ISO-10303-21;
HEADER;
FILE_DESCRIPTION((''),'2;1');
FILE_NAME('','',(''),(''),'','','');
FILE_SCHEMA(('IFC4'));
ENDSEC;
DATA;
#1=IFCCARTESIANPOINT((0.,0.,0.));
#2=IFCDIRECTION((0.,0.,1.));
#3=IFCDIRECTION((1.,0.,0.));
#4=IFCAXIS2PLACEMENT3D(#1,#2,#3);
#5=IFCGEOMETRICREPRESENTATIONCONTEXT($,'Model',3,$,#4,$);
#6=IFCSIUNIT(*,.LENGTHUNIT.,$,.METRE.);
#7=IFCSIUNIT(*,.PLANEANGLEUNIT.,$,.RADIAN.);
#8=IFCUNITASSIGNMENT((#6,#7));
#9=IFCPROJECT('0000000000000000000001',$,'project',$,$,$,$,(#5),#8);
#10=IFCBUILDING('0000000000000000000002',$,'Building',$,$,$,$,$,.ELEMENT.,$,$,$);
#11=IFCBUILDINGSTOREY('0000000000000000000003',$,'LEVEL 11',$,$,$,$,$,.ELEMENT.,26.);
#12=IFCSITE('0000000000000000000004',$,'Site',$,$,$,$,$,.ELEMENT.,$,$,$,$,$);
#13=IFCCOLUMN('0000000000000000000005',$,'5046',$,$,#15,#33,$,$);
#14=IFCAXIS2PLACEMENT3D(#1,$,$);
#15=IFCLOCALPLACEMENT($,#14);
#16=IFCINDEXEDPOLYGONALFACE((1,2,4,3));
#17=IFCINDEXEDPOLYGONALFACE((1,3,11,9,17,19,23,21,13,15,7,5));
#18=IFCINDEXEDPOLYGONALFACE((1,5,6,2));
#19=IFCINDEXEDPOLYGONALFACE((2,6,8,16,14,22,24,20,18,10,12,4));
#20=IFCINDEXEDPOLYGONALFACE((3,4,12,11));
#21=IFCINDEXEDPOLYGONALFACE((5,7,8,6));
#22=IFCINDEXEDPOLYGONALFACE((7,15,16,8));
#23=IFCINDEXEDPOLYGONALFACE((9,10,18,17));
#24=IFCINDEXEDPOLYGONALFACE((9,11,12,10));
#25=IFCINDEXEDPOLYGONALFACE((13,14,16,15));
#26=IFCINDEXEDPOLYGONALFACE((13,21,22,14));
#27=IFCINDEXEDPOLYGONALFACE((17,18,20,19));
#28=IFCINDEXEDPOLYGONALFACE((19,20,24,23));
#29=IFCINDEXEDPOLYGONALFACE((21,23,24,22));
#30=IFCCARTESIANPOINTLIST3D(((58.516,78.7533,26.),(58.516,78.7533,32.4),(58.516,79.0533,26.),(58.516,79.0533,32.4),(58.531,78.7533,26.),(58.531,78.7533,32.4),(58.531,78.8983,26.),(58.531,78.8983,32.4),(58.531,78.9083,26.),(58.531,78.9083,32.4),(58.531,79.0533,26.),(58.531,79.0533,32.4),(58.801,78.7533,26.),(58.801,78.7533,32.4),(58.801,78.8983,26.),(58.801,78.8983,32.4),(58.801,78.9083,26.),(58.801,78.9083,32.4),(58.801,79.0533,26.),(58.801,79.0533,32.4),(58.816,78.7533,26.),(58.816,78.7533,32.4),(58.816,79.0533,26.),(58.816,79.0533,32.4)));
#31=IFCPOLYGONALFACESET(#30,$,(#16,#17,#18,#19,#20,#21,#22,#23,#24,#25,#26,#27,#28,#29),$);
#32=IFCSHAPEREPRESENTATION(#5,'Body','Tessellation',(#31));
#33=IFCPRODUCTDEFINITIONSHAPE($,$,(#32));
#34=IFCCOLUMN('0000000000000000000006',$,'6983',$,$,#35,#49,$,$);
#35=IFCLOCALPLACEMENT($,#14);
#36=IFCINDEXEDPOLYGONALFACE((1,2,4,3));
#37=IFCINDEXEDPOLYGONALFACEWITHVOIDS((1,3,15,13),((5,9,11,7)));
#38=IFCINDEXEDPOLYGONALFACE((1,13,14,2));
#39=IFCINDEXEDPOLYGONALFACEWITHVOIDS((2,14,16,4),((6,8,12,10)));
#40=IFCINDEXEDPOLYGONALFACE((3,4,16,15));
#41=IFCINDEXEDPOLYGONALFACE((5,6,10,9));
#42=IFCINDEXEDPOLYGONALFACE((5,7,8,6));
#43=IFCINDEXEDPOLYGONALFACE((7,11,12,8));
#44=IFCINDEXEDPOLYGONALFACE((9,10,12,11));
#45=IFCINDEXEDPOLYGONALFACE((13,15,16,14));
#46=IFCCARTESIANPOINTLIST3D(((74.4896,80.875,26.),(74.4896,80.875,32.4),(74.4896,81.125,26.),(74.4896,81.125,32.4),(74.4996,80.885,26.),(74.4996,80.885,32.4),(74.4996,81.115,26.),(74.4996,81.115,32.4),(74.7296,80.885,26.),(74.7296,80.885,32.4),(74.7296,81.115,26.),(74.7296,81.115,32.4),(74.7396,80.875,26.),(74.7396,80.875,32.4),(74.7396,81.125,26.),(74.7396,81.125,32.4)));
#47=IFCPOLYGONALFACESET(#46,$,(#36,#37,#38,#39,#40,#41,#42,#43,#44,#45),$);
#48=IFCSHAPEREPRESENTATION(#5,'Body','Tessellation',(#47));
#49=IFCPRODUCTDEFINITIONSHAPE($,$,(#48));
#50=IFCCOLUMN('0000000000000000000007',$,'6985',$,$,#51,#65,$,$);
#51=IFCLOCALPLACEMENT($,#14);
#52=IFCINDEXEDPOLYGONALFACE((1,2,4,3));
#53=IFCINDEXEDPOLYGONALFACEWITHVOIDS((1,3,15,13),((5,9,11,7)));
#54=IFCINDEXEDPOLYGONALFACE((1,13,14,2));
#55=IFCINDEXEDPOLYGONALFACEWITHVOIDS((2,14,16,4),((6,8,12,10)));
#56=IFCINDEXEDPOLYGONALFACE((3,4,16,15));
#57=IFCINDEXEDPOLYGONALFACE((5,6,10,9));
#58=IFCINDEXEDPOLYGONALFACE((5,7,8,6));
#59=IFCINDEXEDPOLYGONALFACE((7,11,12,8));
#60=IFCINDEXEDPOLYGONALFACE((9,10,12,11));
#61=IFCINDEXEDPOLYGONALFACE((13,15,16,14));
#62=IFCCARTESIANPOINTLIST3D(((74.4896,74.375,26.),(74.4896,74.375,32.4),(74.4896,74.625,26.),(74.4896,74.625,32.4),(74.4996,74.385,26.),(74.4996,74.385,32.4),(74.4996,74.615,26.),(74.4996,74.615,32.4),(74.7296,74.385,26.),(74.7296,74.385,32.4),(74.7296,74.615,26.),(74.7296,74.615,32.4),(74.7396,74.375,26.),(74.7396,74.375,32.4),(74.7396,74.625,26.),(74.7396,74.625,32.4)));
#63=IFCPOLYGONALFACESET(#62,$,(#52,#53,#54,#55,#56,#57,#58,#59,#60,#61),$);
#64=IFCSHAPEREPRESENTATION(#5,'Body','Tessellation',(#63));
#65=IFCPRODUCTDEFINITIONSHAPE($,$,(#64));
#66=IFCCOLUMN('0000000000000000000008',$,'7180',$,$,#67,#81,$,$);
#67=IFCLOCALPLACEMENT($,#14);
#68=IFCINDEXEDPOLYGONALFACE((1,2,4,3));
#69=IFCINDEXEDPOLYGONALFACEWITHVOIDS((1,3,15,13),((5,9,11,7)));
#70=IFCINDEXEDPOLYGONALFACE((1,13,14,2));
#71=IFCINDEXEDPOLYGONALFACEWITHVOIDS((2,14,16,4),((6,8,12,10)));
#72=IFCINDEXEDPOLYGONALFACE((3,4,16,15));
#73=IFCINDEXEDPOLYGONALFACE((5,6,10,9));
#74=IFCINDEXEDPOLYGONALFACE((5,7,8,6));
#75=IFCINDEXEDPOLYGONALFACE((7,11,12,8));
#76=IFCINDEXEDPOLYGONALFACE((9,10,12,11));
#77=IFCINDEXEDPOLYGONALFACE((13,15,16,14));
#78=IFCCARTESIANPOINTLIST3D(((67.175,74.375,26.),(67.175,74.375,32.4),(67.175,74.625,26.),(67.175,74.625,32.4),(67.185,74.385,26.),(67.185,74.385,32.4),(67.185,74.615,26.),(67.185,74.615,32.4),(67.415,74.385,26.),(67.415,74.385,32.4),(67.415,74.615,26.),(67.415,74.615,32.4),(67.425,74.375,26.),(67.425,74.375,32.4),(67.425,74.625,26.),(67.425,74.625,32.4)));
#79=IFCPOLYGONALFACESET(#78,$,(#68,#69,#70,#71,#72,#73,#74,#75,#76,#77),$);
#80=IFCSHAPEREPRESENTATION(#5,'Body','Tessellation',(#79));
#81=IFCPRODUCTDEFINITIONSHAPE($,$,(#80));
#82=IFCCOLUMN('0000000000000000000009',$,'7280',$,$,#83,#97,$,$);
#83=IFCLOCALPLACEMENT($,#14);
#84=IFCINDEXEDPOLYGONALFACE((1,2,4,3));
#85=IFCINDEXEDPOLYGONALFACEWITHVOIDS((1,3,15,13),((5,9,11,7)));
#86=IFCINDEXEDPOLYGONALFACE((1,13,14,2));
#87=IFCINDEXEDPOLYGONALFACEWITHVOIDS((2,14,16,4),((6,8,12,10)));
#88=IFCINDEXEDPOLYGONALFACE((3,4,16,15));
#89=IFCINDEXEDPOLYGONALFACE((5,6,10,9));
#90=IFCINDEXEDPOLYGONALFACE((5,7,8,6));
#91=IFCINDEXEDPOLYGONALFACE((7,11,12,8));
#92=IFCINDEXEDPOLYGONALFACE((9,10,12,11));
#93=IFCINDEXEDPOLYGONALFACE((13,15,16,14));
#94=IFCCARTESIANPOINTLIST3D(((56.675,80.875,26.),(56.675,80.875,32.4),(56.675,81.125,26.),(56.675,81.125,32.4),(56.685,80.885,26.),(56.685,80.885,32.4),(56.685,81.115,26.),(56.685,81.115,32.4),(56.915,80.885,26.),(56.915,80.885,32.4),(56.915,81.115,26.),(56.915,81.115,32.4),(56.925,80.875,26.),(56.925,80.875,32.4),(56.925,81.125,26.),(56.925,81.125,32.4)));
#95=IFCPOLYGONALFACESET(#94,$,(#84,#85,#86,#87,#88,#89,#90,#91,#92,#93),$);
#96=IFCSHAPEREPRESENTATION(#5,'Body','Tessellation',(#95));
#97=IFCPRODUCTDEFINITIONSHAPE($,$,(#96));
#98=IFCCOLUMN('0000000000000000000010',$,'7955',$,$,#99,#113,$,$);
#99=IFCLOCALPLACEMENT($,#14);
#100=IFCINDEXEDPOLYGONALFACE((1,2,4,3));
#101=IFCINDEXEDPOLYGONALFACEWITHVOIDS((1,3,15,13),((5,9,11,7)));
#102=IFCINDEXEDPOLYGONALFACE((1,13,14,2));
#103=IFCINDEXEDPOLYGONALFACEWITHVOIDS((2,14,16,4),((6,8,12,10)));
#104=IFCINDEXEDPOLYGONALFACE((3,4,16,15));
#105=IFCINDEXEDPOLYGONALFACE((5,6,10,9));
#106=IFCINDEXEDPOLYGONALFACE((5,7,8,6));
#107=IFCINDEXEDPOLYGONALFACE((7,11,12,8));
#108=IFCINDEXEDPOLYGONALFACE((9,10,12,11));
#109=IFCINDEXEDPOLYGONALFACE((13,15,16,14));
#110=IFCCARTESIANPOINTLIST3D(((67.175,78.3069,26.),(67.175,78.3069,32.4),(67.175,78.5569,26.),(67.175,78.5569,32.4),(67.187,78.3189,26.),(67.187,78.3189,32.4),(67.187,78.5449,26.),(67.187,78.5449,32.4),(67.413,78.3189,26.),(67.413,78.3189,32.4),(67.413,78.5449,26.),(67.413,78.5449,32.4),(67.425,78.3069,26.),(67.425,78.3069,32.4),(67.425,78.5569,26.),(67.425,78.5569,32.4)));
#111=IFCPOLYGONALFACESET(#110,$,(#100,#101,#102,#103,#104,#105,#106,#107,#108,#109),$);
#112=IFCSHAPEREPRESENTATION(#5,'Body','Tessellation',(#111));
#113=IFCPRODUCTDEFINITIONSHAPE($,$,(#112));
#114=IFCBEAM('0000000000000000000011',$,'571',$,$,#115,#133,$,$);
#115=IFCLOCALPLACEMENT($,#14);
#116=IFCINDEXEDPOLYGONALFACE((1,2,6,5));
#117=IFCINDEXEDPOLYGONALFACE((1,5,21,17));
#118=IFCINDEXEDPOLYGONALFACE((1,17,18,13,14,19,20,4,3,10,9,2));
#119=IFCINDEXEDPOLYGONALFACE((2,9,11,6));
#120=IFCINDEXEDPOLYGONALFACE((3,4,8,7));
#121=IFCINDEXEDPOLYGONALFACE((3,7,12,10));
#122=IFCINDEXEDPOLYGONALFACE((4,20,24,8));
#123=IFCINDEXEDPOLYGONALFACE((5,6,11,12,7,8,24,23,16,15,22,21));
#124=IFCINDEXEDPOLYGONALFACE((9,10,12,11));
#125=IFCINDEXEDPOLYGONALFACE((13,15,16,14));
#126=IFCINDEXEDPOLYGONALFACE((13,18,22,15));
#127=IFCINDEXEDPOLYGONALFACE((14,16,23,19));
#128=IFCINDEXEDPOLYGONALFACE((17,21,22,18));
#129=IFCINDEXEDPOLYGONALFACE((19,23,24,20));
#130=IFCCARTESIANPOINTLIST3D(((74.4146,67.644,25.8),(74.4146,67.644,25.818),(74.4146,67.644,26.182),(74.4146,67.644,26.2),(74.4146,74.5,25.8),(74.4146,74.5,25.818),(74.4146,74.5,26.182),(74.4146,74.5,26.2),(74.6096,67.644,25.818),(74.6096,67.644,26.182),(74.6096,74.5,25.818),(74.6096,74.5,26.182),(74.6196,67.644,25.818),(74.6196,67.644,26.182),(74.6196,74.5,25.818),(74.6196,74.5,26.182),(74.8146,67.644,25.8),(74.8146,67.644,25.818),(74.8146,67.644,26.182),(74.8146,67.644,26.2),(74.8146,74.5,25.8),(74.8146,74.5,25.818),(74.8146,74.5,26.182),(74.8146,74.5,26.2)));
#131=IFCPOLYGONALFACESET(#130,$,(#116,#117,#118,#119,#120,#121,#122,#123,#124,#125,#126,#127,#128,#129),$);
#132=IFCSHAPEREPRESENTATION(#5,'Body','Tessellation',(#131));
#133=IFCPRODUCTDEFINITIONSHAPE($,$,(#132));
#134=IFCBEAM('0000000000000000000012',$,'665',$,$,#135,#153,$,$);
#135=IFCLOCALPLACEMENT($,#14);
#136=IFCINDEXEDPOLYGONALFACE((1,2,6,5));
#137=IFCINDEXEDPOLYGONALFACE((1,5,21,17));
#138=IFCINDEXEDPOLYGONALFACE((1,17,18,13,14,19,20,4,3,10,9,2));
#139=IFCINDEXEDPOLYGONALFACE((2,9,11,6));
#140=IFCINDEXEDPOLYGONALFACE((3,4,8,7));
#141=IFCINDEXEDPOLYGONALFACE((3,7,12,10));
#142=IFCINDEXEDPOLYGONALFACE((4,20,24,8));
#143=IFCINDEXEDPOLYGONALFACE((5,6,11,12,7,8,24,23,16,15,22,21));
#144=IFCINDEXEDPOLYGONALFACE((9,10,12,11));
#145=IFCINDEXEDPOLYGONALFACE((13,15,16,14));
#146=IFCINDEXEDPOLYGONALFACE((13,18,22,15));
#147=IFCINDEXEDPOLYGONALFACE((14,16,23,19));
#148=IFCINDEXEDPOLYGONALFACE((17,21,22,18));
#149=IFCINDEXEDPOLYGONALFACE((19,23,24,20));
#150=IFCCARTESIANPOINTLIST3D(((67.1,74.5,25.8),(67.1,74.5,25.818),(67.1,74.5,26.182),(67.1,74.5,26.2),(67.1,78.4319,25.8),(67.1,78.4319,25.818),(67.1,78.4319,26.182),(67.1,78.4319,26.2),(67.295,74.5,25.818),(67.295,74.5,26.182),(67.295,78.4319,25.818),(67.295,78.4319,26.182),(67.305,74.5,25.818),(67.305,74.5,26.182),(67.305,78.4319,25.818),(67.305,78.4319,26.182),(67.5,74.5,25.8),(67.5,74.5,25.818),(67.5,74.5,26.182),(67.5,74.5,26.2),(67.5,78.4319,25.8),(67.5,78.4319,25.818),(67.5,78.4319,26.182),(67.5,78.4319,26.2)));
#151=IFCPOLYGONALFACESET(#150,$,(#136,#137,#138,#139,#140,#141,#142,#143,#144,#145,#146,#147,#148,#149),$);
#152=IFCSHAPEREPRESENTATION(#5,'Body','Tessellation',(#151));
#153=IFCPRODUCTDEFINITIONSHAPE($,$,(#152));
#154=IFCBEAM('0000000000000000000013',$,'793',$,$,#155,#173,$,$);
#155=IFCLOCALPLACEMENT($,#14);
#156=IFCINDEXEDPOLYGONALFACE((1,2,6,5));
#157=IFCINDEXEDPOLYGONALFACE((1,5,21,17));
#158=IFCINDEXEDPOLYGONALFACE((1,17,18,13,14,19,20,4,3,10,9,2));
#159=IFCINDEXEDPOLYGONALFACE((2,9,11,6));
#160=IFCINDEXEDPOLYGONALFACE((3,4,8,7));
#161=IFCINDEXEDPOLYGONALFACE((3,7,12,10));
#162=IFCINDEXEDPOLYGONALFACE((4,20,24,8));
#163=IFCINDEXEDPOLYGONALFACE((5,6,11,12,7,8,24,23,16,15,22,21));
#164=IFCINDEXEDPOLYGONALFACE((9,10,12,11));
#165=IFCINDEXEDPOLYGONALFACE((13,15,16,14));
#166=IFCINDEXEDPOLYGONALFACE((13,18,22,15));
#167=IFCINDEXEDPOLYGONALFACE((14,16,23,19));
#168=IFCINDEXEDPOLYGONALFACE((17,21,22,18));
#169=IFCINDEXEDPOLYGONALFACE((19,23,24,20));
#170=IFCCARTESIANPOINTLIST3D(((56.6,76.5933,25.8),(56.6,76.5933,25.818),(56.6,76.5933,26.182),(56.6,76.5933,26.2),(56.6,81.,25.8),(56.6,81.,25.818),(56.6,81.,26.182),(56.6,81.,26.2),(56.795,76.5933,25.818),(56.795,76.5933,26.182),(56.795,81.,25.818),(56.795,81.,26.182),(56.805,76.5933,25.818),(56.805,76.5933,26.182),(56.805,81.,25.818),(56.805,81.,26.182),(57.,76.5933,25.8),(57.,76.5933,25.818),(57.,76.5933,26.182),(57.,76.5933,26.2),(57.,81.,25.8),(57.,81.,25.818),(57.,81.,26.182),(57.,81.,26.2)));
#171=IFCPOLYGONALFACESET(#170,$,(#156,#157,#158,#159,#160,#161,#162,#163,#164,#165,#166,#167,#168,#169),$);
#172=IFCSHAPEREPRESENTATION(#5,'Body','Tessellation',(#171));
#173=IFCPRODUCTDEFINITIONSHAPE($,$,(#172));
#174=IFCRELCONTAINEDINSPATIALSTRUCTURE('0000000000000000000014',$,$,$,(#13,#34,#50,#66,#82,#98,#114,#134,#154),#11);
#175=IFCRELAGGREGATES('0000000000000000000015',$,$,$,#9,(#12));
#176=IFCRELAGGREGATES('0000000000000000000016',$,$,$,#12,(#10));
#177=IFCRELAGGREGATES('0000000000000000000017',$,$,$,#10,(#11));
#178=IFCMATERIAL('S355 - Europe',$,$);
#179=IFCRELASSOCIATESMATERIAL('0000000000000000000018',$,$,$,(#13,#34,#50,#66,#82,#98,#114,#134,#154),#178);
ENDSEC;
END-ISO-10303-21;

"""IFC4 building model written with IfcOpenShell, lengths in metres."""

from ifc_helpers import new_model, si_unit, frame, origin_with_axes, origin_2d_with_axis, place, context, project, spatial, hollow_rectangle, i_section, extrude, material, material_profile, profile_set, profile_usage, element, save


model = new_model("IFC4")

# Units and contexts
model_context = context("Model", 3, world=origin_with_axes())
ifc_project = project(units=[si_unit("LENGTHUNIT", "METRE"), si_unit("PLANEANGLEUNIT", "RADIAN")], contexts=[model_context])

# Site, building, storey
site = spatial("IfcSite", under=ifc_project, Name="Site", CompositionType="ELEMENT")
building = spatial("IfcBuilding", under=site, Name="Building", CompositionType="ELEMENT")
storey = spatial("IfcBuildingStorey", under=building, Name="LEVEL 11", CompositionType="ELEMENT", Elevation=26.0)

# Columns
ifc_material = material(Name="S355 - Europe")
ifc_material_profile_1 = material_profile(ifc_material, i_section(OverallWidth=0.3, OverallDepth=0.3, WebThickness=0.01, FlangeThickness=0.015, at=origin_2d_with_axis()))
ifc_profile_set_1 = profile_set([ifc_material_profile_1])
ifc_profile_usage_1 = profile_usage(ifc_profile_set_1, cardinal=10)
column_1_placement = place(None, frame((58.666, 78.9033, 26.0), z_axis=(0.0, 0.0, 1.0), x_axis=(0.0, -1.0, 0.0)))
element("IfcColumn", 1, at=column_1_placement, inside=storey, material=ifc_profile_usage_1, Name="5046", context=model_context, shape_type="SweptSolid", body=[
    extrude(i_section(OverallWidth=0.3, OverallDepth=0.3, WebThickness=0.01, FlangeThickness=0.015, at=origin_2d_with_axis()), origin_with_axes(), (0.0, 0.0, 1.0), 6.4),
])
ifc_material_profile_2 = material_profile(ifc_material, hollow_rectangle(XDim=0.25, YDim=0.25, WallThickness=0.01, at=origin_2d_with_axis()))
ifc_profile_set_2 = profile_set([ifc_material_profile_2])
ifc_profile_usage_2 = profile_usage(ifc_profile_set_2, cardinal=10)
column_2_placement = place(None, frame((74.6146, 81.0, 26.0), z_axis=(0.0, 0.0, 1.0), x_axis=(0.0, -1.0, 0.0)))
element("IfcColumn", 2, at=column_2_placement, inside=storey, material=ifc_profile_usage_2, Name="6983", context=model_context, shape_type="SweptSolid", body=[
    extrude(hollow_rectangle(XDim=0.25, YDim=0.25, WallThickness=0.01, at=origin_2d_with_axis()), origin_with_axes(), (0.0, 0.0, 1.0), 6.4),
])
ifc_material_profile_3 = material_profile(ifc_material, hollow_rectangle(XDim=0.25, YDim=0.25, WallThickness=0.01, at=origin_2d_with_axis()))
ifc_profile_set_3 = profile_set([ifc_material_profile_3])
ifc_profile_usage_3 = profile_usage(ifc_profile_set_3, cardinal=10)
column_3_placement = place(None, frame((74.6146, 74.5, 26.0), z_axis=(0.0, 0.0, 1.0), x_axis=(0.0, -1.0, 0.0)))
element("IfcColumn", 3, at=column_3_placement, inside=storey, material=ifc_profile_usage_3, Name="6985", context=model_context, shape_type="SweptSolid", body=[
    extrude(hollow_rectangle(XDim=0.25, YDim=0.25, WallThickness=0.01, at=origin_2d_with_axis()), origin_with_axes(), (0.0, 0.0, 1.0), 6.4),
])
ifc_material_profile_4 = material_profile(ifc_material, hollow_rectangle(XDim=0.25, YDim=0.25, WallThickness=0.01, at=origin_2d_with_axis()))
ifc_profile_set_4 = profile_set([ifc_material_profile_4])
ifc_profile_usage_4 = profile_usage(ifc_profile_set_4, cardinal=10)
column_4_placement = place(None, frame((67.3, 74.5, 32.4), z_axis=(0.0, 0.0, -1.0), x_axis=(0.0, 1.0, 0.0)))
element("IfcColumn", 4, at=column_4_placement, inside=storey, material=ifc_profile_usage_4, Name="7180", context=model_context, shape_type="SweptSolid", body=[
    extrude(hollow_rectangle(XDim=0.25, YDim=0.25, WallThickness=0.01, at=origin_2d_with_axis()), origin_with_axes(), (0.0, 0.0, 1.0), 6.4),
])
ifc_material_profile_5 = material_profile(ifc_material, hollow_rectangle(XDim=0.25, YDim=0.25, WallThickness=0.01, at=origin_2d_with_axis()))
ifc_profile_set_5 = profile_set([ifc_material_profile_5])
ifc_profile_usage_5 = profile_usage(ifc_profile_set_5, cardinal=10)
column_5_placement = place(None, frame((56.8, 81.0, 26.0), z_axis=(0.0, 0.0, 1.0), x_axis=(0.0, -1.0, 0.0)))
element("IfcColumn", 5, at=column_5_placement, inside=storey, material=ifc_profile_usage_5, Name="7280", context=model_context, shape_type="SweptSolid", body=[
    extrude(hollow_rectangle(XDim=0.25, YDim=0.25, WallThickness=0.01, at=origin_2d_with_axis()), origin_with_axes(), (0.0, 0.0, 1.0), 6.4),
])
ifc_material_profile_6 = material_profile(ifc_material, hollow_rectangle(XDim=0.25, YDim=0.25, WallThickness=0.012, at=origin_2d_with_axis()))
ifc_profile_set_6 = profile_set([ifc_material_profile_6])
ifc_profile_usage_6 = profile_usage(ifc_profile_set_6, cardinal=10)
column_6_placement = place(None, frame((67.3, 78.4319, 26.0), z_axis=(0.0, 0.0, 1.0), x_axis=(0.0, -1.0, 0.0)))
element("IfcColumn", 6, at=column_6_placement, inside=storey, material=ifc_profile_usage_6, Name="7955", context=model_context, shape_type="SweptSolid", body=[
    extrude(hollow_rectangle(XDim=0.25, YDim=0.25, WallThickness=0.012, at=origin_2d_with_axis()), origin_with_axes(), (0.0, 0.0, 1.0), 6.4),
])

# Beams
ifc_material_profile_7 = material_profile(ifc_material, i_section(OverallWidth=0.4, OverallDepth=0.4, WebThickness=0.01, FlangeThickness=0.018, at=origin_2d_with_axis()))
ifc_profile_set_7 = profile_set([ifc_material_profile_7])
ifc_profile_usage_7 = profile_usage(ifc_profile_set_7, cardinal=10)
beam_1_placement = place(None, frame((74.6146, 74.5, 26.0), z_axis=(0.0, -1.0, 0.0), x_axis=(1.0, 0.0, 0.0)))
element("IfcBeam", 7, at=beam_1_placement, inside=storey, material=ifc_profile_usage_7, Name="571", context=model_context, shape_type="SweptSolid", body=[
    extrude(i_section(OverallWidth=0.4, OverallDepth=0.4, WebThickness=0.01, FlangeThickness=0.018, at=origin_2d_with_axis()), origin_with_axes(), (0.0, 0.0, 1.0), 6.856),
])
ifc_material_profile_8 = material_profile(ifc_material, i_section(OverallWidth=0.4, OverallDepth=0.4, WebThickness=0.01, FlangeThickness=0.018, at=origin_2d_with_axis()))
ifc_profile_set_8 = profile_set([ifc_material_profile_8])
ifc_profile_usage_8 = profile_usage(ifc_profile_set_8, cardinal=10)
beam_2_placement = place(None, frame((67.3, 74.5, 26.0), z_axis=(0.0, 1.0, 0.0), x_axis=(-1.0, 0.0, 0.0)))
element("IfcBeam", 8, at=beam_2_placement, inside=storey, material=ifc_profile_usage_8, Name="665", context=model_context, shape_type="SweptSolid", body=[
    extrude(i_section(OverallWidth=0.4, OverallDepth=0.4, WebThickness=0.01, FlangeThickness=0.018, at=origin_2d_with_axis()), origin_with_axes(), (0.0, 0.0, 1.0), 3.9319),
])
ifc_material_profile_9 = material_profile(ifc_material, i_section(OverallWidth=0.4, OverallDepth=0.4, WebThickness=0.01, FlangeThickness=0.018, at=origin_2d_with_axis()))
ifc_profile_set_9 = profile_set([ifc_material_profile_9])
ifc_profile_usage_9 = profile_usage(ifc_profile_set_9, cardinal=10)
beam_3_placement = place(None, frame((56.8, 81.0, 26.0), z_axis=(0.0, -1.0, 0.0), x_axis=(1.0, 0.0, 0.0)))
element("IfcBeam", 9, at=beam_3_placement, inside=storey, material=ifc_profile_usage_9, Name="793", context=model_context, shape_type="SweptSolid", body=[
    extrude(i_section(OverallWidth=0.4, OverallDepth=0.4, WebThickness=0.01, FlangeThickness=0.018, at=origin_2d_with_axis()), origin_with_axes(), (0.0, 0.0, 1.0), 4.4067),
])

save(model, "model.ifc")
